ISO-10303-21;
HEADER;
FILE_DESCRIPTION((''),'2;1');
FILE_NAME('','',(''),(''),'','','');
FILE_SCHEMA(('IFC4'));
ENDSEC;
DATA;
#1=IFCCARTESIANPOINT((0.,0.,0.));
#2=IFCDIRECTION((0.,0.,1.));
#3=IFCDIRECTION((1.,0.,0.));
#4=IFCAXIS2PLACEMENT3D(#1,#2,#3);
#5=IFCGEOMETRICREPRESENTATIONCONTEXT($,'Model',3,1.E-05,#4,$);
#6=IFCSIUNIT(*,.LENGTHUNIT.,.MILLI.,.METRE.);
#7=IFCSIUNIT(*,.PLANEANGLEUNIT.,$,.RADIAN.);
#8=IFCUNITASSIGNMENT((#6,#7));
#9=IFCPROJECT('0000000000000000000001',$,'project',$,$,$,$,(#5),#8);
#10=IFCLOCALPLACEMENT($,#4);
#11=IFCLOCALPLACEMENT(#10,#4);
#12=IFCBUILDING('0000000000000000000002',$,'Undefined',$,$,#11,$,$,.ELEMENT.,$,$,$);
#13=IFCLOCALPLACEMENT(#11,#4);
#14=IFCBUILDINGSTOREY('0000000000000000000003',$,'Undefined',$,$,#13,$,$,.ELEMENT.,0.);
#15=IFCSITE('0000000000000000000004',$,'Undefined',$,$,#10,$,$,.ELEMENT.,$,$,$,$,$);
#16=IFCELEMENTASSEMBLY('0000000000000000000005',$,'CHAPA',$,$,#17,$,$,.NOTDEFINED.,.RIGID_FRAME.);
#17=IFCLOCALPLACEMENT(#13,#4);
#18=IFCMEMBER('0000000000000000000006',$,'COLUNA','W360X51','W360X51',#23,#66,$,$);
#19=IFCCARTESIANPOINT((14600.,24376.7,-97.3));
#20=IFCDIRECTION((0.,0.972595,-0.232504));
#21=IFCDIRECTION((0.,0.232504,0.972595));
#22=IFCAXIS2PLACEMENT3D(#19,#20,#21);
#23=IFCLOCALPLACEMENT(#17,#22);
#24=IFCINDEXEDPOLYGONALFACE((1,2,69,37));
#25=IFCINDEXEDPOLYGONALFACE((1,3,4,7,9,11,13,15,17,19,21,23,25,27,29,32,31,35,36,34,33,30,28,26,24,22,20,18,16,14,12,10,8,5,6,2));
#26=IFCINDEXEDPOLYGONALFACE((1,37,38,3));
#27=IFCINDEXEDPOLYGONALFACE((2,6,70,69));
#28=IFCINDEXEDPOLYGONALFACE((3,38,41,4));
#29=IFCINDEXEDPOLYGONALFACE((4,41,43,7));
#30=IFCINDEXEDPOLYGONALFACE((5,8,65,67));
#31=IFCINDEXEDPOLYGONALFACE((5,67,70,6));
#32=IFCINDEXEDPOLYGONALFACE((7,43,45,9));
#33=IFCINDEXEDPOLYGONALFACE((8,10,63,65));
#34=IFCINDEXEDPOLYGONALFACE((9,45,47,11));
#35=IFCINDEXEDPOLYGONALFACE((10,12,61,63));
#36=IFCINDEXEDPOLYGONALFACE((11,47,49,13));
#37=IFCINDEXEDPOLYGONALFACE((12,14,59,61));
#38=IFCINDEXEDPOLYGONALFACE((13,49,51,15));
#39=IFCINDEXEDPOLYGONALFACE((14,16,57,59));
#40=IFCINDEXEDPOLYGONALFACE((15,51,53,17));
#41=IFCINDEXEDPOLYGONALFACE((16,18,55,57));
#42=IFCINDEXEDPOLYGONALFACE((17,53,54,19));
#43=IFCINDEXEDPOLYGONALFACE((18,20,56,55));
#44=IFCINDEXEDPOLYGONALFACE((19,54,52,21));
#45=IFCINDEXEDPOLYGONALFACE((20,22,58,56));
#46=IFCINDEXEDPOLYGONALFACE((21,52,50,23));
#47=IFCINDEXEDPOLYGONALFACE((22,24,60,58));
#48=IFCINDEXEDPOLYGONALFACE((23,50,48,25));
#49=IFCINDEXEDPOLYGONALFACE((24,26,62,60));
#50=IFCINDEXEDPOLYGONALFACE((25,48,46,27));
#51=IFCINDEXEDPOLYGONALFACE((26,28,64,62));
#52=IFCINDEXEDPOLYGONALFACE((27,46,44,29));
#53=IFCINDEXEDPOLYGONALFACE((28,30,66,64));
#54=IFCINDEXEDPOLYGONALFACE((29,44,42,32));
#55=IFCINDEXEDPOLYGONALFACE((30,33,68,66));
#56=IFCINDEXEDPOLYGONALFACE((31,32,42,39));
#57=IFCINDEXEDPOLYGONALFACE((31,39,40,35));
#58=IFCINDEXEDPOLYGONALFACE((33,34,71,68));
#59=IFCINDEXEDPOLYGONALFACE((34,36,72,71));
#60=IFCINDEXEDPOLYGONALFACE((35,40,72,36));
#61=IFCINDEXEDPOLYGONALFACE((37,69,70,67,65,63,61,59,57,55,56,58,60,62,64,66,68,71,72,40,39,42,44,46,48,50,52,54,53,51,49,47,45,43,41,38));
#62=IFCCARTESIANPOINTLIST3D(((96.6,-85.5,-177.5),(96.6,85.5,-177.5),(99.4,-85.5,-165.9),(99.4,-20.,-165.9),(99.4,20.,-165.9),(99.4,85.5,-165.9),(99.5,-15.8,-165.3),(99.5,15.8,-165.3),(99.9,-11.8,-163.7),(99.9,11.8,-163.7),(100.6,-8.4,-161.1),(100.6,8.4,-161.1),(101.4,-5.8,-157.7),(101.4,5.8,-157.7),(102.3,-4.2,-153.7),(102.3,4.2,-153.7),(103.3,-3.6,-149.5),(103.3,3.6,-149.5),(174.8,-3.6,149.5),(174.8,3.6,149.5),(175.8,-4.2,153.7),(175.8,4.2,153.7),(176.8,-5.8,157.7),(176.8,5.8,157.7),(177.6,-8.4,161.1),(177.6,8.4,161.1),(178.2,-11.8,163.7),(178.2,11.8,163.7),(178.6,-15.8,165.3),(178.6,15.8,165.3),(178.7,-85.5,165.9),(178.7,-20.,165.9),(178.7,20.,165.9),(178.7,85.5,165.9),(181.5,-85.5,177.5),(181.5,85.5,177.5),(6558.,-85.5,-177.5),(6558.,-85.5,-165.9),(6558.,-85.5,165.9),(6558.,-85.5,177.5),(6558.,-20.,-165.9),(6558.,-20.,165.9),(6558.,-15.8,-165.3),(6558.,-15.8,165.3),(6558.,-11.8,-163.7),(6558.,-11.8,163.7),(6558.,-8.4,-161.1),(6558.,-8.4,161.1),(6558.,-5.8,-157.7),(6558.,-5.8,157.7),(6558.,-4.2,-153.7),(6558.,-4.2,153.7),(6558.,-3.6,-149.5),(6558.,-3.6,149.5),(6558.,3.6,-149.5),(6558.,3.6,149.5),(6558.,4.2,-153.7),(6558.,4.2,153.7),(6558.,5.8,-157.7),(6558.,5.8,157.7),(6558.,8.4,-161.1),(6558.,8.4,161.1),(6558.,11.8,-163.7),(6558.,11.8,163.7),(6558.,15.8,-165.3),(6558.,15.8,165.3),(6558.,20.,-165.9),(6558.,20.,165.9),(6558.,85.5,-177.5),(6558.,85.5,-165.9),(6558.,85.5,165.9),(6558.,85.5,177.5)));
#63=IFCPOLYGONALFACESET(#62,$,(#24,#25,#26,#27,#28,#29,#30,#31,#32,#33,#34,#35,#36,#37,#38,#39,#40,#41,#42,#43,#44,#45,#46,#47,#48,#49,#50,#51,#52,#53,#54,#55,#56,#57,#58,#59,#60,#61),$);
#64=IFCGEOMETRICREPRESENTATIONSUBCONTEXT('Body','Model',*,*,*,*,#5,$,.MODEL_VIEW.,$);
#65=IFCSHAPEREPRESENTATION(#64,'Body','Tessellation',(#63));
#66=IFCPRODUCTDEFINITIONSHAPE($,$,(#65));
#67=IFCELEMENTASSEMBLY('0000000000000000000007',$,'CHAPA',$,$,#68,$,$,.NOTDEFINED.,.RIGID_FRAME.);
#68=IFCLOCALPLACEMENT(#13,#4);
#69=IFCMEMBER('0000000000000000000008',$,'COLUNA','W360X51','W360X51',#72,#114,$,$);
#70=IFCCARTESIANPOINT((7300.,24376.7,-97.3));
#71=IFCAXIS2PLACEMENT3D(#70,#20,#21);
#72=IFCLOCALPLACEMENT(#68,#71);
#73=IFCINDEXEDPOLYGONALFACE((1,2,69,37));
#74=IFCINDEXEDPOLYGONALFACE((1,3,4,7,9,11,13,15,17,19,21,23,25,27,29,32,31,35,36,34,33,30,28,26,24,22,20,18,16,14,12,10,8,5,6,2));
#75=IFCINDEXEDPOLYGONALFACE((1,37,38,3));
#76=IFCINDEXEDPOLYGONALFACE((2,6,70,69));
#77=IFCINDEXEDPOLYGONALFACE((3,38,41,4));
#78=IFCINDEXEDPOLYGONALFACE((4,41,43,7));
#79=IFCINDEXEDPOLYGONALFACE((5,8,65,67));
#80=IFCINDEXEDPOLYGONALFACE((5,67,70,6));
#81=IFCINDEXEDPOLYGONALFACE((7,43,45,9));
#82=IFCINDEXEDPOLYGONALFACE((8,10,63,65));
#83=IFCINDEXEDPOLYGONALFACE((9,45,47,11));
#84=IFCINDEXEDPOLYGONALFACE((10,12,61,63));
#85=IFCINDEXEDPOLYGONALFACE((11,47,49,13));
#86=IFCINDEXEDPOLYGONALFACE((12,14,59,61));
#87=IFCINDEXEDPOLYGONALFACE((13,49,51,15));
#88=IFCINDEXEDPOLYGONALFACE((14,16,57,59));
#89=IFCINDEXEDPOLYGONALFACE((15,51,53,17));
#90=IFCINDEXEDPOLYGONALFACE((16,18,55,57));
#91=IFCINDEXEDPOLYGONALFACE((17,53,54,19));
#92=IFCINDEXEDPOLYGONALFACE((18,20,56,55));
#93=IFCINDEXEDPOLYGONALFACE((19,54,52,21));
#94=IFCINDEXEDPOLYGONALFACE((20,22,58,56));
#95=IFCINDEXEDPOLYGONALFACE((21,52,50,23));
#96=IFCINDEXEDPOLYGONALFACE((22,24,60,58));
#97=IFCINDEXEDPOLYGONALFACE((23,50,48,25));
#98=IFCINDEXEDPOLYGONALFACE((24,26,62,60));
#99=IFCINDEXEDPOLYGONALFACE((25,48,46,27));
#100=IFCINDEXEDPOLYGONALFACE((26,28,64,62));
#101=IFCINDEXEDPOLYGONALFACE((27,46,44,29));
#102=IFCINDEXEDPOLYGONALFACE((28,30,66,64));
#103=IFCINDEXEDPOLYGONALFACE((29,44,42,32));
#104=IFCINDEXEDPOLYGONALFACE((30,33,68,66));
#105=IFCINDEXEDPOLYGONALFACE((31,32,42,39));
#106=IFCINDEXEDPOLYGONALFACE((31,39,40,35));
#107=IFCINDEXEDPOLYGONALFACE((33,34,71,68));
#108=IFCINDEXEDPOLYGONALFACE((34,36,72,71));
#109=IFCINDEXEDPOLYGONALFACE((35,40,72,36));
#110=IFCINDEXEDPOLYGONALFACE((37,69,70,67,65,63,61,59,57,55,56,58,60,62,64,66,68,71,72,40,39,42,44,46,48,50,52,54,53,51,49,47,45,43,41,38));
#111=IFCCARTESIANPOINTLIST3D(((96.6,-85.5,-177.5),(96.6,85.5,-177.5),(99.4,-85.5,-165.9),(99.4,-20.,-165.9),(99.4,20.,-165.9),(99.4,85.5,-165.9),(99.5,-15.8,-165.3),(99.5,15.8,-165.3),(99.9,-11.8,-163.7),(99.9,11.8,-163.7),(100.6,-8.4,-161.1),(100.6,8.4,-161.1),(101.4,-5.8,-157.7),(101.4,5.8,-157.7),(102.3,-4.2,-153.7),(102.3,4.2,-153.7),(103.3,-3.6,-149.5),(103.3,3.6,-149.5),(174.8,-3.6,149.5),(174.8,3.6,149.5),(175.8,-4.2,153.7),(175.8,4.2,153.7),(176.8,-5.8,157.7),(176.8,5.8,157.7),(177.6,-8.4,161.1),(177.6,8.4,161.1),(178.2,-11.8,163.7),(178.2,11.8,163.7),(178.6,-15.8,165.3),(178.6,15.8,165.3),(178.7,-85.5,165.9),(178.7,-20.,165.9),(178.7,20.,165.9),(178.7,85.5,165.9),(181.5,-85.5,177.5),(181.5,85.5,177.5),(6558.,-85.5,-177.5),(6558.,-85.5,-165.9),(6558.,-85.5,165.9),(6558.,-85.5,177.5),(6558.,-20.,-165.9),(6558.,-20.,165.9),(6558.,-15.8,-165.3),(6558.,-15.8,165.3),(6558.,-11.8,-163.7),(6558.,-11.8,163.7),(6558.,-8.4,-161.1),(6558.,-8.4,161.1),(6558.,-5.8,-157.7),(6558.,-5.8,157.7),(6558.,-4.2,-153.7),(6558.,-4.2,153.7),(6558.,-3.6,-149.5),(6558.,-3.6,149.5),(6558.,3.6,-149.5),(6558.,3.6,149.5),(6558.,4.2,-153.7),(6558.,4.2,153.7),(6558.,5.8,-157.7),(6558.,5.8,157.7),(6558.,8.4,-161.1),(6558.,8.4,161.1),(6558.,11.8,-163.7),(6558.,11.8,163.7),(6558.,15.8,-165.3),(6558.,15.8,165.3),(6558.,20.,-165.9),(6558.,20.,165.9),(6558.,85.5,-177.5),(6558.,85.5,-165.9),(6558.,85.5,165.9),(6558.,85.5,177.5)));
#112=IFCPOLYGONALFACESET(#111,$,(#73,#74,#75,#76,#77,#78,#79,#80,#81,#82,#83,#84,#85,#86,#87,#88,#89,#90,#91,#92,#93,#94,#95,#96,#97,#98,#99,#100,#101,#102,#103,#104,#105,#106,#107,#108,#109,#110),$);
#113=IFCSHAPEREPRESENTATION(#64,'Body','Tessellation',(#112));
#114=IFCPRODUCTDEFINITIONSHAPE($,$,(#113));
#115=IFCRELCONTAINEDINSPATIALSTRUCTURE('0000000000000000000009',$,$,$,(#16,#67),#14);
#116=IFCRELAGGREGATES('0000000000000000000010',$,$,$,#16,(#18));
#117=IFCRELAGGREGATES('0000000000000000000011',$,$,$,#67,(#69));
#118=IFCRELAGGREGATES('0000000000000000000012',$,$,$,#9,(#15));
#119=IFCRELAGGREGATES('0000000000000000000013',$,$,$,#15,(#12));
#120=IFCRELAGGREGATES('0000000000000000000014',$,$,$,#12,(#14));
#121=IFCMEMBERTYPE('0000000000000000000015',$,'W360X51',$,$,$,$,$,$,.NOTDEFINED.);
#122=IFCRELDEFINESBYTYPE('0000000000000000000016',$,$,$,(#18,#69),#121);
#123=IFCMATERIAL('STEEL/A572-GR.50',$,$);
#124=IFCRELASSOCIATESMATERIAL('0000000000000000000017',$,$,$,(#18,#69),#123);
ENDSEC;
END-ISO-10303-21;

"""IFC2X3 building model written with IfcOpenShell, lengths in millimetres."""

from ifc_helpers import new_model, si_unit, frame, origin_with_axes, origin_2d_with_axis, place, context, subcontext, project, spatial, i_section, extrude, clip, halfspace, material, type_object, element, aggregate, save


model = new_model("IFC2X3")

# Units and contexts
model_context = context("Model", 3, precision=1e-05, world=origin_with_axes())
body_context = subcontext(model_context, "Body", "Model", "MODEL_VIEW")
ifc_project = project(units=[si_unit("LENGTHUNIT", "METRE", prefix="MILLI"), si_unit("PLANEANGLEUNIT", "RADIAN")], contexts=[model_context])

# Site, building, storey
site_placement = place(None, origin_with_axes())
site = spatial("IfcSite", under=ifc_project, at=site_placement, Name="Undefined", CompositionType="ELEMENT")
building_placement = place(site_placement, origin_with_axes())
building = spatial("IfcBuilding", under=site, at=building_placement, Name="Undefined", CompositionType="ELEMENT")
storey_placement = place(building_placement, origin_with_axes())
storey = spatial("IfcBuildingStorey", under=building, at=storey_placement, Name="Undefined", CompositionType="ELEMENT", Elevation=0.0)

# Element assemblies, members
assembly_1_placement = place(storey_placement, origin_with_axes())
assembly_1 = element("IfcElementAssembly", 1, at=assembly_1_placement, inside=storey, Name="CHAPA", AssemblyPlace="NOTDEFINED", PredefinedType="RIGID_FRAME")
ifc_material_1 = material(Name="STEEL/A572-GR.50")
member_type = type_object("IfcMemberType", Name="W360X51", PredefinedType="NOTDEFINED")
member_1_placement = place(assembly_1_placement, frame((14600.0, 24376.7, -97.3), z_axis=(0.0, 0.972595, -0.232504), x_axis=(0.0, 0.232504, 0.972595)))
member_1 = element("IfcMember", 2, at=member_1_placement, type_object=member_type, material=ifc_material_1, Name="COLUNA", Description="W360X51", ObjectType="W360X51", context=body_context, shape_type="Clipping", body=[
    clip(clip(extrude(i_section(OverallWidth=171.0, OverallDepth=355.0, WebThickness=7.2, FlangeThickness=11.6, FilletRadius=16.4, at=origin_2d_with_axis()), frame((6558.0, 0.0, 0.0), z_axis=(-1.0, 0.0, 0.0), x_axis=(0.0, -1.0, 0.0)), (0.0, 0.0, 1.0), 6542.9), halfspace(frame((94.5, -85.5, -186.3), z_axis=(-0.972595, 0.0, 0.232504), x_axis=(0.0, 1.0, 0.0)), False)), halfspace(frame((96.6, 0.0, -177.5), z_axis=(0.972595, 0.0, -0.232504), x_axis=(0.0, -1.0, 0.0)), True)),
])
assembly_2_placement = place(storey_placement, origin_with_axes())
assembly_2 = element("IfcElementAssembly", 3, at=assembly_2_placement, inside=storey, Name="CHAPA", AssemblyPlace="NOTDEFINED", PredefinedType="RIGID_FRAME")
member_2_placement = place(assembly_2_placement, frame((7300.0, 24376.7, -97.3), z_axis=(0.0, 0.972595, -0.232504), x_axis=(0.0, 0.232504, 0.972595)))
member_2 = element("IfcMember", 4, at=member_2_placement, type_object=member_type, material=ifc_material_1, Name="COLUNA", Description="W360X51", ObjectType="W360X51", context=body_context, shape_type="Clipping", body=[
    clip(clip(extrude(i_section(OverallWidth=171.0, OverallDepth=355.0, WebThickness=7.2, FlangeThickness=11.6, FilletRadius=16.4, at=origin_2d_with_axis()), frame((6558.0, 0.0, 0.0), z_axis=(-1.0, 0.0, 0.0), x_axis=(0.0, -1.0, 0.0)), (0.0, 0.0, 1.0), 6542.9), halfspace(frame((94.5, -85.5, -186.3), z_axis=(-0.972595, 0.0, 0.232504), x_axis=(0.0, 1.0, 0.0)), False)), halfspace(frame((96.6, 0.0, -177.5), z_axis=(0.972595, 0.0, -0.232504), x_axis=(0.0, -1.0, 0.0)), True)),
])

aggregate(assembly_1, [member_1])
aggregate(assembly_2, [member_2])

save(model, "model.ifc")
